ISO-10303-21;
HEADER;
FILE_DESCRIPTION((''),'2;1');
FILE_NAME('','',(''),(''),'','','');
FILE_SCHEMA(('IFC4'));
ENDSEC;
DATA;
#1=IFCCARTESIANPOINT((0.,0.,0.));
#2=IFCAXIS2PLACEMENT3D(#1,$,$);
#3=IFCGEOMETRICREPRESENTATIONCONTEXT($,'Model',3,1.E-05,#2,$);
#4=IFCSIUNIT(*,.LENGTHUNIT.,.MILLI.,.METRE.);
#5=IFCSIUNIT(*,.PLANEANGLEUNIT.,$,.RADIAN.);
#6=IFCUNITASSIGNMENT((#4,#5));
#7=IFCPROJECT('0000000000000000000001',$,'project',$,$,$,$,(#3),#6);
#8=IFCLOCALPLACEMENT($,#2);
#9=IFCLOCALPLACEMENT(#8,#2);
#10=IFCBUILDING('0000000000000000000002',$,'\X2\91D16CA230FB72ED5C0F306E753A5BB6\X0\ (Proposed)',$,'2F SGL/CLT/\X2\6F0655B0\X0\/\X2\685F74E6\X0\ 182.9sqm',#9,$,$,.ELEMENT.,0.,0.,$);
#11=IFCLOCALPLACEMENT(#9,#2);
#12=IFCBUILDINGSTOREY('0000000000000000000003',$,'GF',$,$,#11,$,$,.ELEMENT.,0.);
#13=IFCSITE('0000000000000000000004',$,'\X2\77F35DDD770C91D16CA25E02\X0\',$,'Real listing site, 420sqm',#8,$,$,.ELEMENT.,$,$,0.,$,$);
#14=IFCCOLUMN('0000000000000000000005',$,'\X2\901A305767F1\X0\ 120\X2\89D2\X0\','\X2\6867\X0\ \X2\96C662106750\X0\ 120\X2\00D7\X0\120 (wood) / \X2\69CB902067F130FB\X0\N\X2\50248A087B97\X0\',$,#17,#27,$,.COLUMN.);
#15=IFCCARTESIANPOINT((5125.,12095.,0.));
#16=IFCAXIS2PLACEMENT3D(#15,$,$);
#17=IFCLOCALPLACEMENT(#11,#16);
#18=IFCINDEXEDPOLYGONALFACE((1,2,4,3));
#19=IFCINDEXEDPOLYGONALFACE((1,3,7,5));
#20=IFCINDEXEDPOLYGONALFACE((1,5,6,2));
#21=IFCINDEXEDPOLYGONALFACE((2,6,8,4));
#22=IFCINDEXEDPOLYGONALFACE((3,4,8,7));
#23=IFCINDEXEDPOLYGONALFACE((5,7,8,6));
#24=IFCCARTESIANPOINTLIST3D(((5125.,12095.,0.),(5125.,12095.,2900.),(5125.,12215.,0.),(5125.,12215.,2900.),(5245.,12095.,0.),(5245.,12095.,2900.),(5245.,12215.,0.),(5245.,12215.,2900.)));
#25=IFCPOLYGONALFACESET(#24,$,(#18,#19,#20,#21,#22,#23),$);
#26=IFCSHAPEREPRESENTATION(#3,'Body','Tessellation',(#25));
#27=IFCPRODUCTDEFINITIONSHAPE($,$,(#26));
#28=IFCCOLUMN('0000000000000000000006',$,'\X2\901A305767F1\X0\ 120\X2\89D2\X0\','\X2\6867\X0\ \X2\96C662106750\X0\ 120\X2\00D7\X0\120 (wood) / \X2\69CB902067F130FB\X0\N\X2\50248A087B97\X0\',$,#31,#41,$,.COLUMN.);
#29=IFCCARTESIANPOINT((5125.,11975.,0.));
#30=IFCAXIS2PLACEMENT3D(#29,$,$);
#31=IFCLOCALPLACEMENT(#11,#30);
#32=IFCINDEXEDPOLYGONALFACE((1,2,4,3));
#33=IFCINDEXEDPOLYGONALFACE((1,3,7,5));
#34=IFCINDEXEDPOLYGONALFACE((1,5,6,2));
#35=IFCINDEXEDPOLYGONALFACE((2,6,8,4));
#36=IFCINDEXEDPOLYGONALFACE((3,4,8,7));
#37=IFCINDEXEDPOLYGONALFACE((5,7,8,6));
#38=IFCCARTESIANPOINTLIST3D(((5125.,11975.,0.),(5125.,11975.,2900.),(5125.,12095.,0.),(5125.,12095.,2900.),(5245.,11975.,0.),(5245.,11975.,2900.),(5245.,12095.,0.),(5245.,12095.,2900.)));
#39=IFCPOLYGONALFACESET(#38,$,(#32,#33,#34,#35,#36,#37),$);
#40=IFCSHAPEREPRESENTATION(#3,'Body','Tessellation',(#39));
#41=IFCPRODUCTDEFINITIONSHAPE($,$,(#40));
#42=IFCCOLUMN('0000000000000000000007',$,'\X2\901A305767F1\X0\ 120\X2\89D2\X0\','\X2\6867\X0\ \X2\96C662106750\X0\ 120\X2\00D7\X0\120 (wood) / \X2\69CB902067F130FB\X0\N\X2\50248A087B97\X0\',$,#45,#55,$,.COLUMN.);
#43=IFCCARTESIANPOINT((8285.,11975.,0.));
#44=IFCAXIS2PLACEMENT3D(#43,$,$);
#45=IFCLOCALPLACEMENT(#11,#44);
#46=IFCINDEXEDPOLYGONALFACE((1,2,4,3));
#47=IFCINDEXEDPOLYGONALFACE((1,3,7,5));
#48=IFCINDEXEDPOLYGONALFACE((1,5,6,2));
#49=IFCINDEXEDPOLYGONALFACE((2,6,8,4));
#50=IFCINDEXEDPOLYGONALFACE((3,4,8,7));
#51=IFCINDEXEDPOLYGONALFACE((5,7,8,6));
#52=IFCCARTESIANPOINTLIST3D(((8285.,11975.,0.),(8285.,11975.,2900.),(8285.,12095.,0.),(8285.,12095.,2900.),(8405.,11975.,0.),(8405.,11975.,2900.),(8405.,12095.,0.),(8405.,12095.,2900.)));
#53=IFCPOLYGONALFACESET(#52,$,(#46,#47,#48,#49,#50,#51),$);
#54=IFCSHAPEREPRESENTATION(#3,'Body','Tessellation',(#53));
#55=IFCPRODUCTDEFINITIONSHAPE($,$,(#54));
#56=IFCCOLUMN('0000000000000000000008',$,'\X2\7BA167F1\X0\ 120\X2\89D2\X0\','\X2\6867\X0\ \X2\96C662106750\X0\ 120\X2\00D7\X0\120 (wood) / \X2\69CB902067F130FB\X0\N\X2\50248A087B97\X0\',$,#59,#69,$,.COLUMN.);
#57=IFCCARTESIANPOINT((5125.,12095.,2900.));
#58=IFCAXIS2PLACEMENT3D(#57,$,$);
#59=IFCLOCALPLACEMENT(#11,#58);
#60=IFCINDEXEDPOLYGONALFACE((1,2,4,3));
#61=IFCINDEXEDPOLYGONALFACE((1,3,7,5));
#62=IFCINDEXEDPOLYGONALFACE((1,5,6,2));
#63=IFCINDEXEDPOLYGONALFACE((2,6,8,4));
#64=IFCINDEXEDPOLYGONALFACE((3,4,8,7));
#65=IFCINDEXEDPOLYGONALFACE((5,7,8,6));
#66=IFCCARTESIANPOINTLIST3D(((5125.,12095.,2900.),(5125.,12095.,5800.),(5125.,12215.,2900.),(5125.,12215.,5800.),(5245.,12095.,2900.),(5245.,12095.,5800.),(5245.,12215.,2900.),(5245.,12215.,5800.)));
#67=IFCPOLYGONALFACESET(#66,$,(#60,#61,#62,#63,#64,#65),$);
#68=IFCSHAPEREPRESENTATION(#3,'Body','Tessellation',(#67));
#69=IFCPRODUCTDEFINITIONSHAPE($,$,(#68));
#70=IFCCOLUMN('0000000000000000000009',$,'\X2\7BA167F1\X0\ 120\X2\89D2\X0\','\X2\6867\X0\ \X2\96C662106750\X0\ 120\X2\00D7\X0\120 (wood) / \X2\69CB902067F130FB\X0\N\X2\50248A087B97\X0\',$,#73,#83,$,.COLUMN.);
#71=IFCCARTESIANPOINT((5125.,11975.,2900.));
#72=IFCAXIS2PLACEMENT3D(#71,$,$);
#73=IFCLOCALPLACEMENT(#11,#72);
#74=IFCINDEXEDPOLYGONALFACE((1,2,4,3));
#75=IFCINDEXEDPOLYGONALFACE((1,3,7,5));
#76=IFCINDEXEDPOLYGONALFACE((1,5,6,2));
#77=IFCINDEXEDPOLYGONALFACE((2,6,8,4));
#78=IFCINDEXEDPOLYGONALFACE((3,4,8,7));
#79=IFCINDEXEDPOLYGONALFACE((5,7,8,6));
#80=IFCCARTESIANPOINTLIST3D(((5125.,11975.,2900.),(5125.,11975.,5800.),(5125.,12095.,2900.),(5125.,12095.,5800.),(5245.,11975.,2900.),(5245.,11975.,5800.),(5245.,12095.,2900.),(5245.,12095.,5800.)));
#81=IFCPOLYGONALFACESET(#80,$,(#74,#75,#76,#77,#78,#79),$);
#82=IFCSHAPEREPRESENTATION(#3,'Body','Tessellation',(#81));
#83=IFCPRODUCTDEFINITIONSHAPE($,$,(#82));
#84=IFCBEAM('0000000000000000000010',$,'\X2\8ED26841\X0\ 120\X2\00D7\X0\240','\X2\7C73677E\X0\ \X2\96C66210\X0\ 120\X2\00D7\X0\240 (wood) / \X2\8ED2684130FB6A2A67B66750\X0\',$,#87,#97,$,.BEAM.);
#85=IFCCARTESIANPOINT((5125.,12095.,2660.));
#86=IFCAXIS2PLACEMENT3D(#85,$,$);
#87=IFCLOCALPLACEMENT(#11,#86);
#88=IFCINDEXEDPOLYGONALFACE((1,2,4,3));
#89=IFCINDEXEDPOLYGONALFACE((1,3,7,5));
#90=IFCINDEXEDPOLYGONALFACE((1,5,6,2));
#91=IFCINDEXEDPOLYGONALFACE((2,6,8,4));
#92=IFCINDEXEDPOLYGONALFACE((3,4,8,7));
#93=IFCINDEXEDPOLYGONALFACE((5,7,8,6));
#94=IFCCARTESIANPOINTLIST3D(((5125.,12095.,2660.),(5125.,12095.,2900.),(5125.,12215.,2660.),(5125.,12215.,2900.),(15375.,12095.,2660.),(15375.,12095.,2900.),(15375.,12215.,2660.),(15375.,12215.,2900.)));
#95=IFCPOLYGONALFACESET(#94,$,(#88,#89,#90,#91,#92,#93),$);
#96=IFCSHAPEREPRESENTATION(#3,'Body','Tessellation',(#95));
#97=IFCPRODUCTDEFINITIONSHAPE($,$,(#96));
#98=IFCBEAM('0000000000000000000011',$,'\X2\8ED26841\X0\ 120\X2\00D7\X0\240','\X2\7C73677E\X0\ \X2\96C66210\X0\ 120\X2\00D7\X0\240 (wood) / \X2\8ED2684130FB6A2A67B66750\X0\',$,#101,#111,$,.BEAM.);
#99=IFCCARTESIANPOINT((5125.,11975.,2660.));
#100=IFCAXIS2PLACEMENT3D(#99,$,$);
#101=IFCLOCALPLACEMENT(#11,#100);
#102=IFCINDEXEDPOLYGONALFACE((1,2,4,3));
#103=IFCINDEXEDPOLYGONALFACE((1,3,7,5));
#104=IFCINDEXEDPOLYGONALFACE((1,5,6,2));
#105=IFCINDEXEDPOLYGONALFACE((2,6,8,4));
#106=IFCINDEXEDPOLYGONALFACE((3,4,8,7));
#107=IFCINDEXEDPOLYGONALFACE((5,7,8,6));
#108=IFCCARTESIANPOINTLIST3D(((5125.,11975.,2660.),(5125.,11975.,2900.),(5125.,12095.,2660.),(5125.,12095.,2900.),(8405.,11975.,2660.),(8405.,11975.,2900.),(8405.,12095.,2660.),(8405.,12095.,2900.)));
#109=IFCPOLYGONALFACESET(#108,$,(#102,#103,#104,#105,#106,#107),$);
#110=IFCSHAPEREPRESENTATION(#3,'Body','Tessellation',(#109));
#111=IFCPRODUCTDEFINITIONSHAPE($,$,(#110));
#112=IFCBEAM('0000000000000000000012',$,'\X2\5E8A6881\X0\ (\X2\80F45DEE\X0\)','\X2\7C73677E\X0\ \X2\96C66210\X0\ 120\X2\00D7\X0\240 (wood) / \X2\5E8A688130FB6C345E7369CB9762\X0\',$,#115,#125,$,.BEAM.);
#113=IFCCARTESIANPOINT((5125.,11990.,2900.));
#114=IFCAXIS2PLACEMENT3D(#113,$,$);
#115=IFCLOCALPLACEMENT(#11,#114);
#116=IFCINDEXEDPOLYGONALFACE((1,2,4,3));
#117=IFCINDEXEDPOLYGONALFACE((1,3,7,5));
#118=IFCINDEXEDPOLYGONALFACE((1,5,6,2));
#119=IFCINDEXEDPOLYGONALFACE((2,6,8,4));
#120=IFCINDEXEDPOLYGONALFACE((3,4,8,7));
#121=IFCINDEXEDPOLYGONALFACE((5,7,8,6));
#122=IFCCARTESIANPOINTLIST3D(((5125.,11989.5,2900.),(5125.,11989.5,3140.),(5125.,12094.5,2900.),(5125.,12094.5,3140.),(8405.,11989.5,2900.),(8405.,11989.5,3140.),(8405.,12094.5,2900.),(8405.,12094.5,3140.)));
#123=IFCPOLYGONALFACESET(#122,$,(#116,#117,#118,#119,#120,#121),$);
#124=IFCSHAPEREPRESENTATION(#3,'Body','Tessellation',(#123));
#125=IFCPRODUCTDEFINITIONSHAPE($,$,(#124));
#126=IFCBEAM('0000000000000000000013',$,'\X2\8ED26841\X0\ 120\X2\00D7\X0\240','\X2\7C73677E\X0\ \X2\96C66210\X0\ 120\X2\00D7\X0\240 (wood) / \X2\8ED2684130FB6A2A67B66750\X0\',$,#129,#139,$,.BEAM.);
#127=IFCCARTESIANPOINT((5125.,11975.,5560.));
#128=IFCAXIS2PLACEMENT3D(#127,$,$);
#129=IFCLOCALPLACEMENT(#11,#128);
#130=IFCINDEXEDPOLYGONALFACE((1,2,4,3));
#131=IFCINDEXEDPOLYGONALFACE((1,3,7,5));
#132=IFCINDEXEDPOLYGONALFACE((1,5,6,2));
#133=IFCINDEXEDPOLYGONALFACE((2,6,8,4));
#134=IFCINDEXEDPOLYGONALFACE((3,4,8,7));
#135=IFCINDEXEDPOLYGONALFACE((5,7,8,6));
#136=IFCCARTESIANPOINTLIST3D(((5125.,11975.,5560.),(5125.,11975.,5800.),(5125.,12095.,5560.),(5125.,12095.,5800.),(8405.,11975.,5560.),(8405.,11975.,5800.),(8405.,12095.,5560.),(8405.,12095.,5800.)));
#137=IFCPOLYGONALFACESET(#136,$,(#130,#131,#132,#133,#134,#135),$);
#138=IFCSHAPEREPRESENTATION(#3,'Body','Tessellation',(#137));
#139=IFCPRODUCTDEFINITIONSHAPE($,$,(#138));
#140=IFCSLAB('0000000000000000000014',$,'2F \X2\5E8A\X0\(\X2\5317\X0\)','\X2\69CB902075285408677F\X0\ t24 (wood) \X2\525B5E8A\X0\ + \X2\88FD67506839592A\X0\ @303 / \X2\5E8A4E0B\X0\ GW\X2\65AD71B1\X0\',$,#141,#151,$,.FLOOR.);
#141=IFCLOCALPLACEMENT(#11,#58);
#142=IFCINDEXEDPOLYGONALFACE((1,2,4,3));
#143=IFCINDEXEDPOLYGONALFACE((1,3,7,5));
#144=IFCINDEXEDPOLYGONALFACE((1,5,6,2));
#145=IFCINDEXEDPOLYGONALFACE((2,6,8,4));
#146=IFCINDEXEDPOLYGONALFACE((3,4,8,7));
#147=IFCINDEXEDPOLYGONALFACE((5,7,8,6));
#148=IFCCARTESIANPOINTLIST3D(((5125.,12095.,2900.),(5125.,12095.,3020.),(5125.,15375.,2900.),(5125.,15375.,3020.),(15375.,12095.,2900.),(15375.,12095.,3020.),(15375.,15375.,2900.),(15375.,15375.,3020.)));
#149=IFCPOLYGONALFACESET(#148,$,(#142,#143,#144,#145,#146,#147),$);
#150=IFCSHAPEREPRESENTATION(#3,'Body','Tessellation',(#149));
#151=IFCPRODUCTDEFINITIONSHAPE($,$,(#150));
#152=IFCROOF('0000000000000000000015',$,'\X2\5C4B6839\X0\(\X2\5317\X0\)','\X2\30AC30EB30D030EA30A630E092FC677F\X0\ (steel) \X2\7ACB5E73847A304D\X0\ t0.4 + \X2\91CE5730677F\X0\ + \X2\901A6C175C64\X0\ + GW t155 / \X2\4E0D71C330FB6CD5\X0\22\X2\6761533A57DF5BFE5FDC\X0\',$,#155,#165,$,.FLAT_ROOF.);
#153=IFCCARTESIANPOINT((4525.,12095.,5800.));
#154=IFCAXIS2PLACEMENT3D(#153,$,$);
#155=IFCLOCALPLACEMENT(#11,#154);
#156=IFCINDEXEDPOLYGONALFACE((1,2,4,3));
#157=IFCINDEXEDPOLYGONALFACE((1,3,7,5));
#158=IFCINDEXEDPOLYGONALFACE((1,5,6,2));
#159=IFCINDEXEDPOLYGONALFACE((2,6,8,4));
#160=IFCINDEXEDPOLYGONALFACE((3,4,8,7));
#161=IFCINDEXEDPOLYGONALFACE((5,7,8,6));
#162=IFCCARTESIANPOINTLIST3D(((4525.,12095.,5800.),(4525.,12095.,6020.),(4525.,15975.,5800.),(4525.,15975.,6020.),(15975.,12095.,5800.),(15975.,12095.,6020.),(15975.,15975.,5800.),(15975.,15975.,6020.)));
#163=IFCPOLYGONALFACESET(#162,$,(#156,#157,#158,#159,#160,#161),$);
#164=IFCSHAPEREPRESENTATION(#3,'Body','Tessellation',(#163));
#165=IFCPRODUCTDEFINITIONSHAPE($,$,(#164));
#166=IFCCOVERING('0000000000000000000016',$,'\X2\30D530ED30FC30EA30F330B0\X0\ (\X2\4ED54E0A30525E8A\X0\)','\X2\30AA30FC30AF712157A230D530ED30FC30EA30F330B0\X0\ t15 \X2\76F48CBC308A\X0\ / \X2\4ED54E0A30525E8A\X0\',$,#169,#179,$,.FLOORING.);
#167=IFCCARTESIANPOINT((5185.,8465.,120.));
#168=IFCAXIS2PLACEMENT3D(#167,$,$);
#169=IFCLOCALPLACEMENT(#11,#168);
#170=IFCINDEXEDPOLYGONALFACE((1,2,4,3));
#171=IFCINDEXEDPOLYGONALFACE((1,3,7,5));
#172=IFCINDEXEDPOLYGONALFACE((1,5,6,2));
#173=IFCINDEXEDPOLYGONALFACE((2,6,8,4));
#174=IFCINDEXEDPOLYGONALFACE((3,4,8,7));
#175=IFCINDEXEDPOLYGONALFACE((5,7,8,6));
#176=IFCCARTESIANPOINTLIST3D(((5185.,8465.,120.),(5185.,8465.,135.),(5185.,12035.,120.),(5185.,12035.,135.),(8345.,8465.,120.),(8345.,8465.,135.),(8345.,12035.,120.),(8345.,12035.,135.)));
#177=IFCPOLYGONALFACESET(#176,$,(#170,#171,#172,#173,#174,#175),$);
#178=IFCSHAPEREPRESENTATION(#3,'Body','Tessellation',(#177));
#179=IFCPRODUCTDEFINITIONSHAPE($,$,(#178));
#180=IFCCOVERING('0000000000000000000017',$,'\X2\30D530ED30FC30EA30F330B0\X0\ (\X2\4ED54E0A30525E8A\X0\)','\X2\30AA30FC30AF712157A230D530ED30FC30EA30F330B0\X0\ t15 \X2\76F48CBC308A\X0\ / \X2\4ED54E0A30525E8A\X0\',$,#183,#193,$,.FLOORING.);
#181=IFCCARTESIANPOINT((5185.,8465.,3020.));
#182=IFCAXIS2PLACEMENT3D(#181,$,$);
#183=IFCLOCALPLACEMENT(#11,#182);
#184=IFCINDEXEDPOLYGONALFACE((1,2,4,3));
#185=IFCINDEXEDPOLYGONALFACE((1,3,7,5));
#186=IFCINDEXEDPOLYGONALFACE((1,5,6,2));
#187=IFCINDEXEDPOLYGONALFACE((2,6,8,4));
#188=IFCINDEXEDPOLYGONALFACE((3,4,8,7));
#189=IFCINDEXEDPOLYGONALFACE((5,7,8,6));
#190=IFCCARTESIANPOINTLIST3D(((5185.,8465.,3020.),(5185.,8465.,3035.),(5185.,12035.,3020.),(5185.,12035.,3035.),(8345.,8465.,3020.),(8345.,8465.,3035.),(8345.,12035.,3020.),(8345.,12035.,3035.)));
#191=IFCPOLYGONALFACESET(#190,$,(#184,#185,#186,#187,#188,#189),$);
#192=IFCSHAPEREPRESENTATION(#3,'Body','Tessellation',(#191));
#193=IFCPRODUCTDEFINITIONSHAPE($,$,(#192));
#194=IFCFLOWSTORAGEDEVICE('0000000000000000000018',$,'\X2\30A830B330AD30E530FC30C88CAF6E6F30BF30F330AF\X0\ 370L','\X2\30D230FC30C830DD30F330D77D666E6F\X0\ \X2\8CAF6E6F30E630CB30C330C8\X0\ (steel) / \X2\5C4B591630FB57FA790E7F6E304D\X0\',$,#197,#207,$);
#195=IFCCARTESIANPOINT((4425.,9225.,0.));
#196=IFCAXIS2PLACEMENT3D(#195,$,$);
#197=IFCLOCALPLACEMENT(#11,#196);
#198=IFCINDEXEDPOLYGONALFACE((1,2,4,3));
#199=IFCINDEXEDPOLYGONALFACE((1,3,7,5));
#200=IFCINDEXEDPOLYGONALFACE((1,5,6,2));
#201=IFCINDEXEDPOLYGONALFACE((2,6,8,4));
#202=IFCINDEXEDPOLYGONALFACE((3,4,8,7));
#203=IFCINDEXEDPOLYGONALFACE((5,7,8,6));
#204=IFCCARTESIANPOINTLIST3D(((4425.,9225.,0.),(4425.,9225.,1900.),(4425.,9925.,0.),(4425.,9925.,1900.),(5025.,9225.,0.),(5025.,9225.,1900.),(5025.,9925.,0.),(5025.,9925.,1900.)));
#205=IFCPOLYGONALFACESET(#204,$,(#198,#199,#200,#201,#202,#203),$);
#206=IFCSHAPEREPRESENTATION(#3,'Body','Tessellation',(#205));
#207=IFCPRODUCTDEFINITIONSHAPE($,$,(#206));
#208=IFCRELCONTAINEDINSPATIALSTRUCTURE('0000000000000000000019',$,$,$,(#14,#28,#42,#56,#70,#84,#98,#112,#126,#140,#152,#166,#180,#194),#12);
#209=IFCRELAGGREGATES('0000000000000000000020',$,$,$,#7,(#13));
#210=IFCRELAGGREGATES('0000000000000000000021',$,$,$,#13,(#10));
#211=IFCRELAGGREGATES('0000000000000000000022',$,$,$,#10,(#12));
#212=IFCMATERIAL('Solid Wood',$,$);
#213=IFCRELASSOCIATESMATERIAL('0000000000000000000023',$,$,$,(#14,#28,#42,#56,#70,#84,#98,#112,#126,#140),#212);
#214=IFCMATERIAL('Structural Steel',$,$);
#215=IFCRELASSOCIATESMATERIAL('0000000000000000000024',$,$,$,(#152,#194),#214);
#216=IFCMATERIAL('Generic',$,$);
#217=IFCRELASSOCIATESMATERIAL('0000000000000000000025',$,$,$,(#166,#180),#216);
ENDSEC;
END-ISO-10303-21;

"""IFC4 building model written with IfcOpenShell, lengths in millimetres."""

from ifc_helpers import new_model, si_unit, frame, frame_2d, origin, place, context, project, spatial, rectangle, extrude, material, element, save


model = new_model("IFC4")

# Units and contexts
model_context = context("Model", 3, precision=1e-05, world=origin())
ifc_project = project(units=[si_unit("LENGTHUNIT", "METRE", prefix="MILLI"), si_unit("PLANEANGLEUNIT", "RADIAN")], contexts=[model_context])

# Site, building, storey
site_placement = place(None, origin())
site = spatial("IfcSite", under=ifc_project, at=site_placement, Name="石川県金沢市", ObjectType="Real listing site, 420sqm", CompositionType="ELEMENT", RefElevation=0.0)
building_placement = place(site_placement, origin())
building = spatial("IfcBuilding", under=site, at=building_placement, Name="金沢・狭小の町家 (Proposed)", ObjectType="2F SGL/CLT/漆喰/桟瓦 182.9sqm", CompositionType="ELEMENT", ElevationOfRefHeight=0.0, ElevationOfTerrain=0.0)
storey_placement = place(building_placement, origin())
storey = spatial("IfcBuildingStorey", under=building, at=storey_placement, Name="GF", CompositionType="ELEMENT", Elevation=0.0)

# Columns
ifc_material_1 = material(Name="Solid Wood")
column_1_placement = place(storey_placement, frame((5125.0, 12095.0, 0.0)))
element("IfcColumn", 1, at=column_1_placement, inside=storey, material=ifc_material_1, Name="通し柱 120角", Description="桧 集成材 120×120 (wood) / 構造柱・N値計算", PredefinedType="COLUMN", context=model_context, shape_type="SweptSolid", body=[
    extrude(rectangle(XDim=120.0, YDim=120.0, at=frame_2d((60.0, 60.0))), frame((5125.0, 12095.0, 0.0)), (0.0, 0.0, 1.0), 2900.0),
])
column_2_placement = place(storey_placement, frame((5125.0, 11975.0, 0.0)))
element("IfcColumn", 2, at=column_2_placement, inside=storey, material=ifc_material_1, Name="通し柱 120角", Description="桧 集成材 120×120 (wood) / 構造柱・N値計算", PredefinedType="COLUMN", context=model_context, shape_type="SweptSolid", body=[
    extrude(rectangle(XDim=120.0, YDim=120.0, at=frame_2d((60.0, 60.0))), frame((5125.0, 11975.0, 0.0)), (0.0, 0.0, 1.0), 2900.0),
])
column_3_placement = place(storey_placement, frame((8285.0, 11975.0, 0.0)))
element("IfcColumn", 3, at=column_3_placement, inside=storey, material=ifc_material_1, Name="通し柱 120角", Description="桧 集成材 120×120 (wood) / 構造柱・N値計算", PredefinedType="COLUMN", context=model_context, shape_type="SweptSolid", body=[
    extrude(rectangle(XDim=120.0, YDim=120.0, at=frame_2d((60.0, 60.0))), frame((8285.0, 11975.0, 0.0)), (0.0, 0.0, 1.0), 2900.0),
])
column_4_placement = place(storey_placement, frame((5125.0, 12095.0, 2900.0)))
element("IfcColumn", 4, at=column_4_placement, inside=storey, material=ifc_material_1, Name="管柱 120角", Description="桧 集成材 120×120 (wood) / 構造柱・N値計算", PredefinedType="COLUMN", context=model_context, shape_type="SweptSolid", body=[
    extrude(rectangle(XDim=120.0, YDim=120.0, at=frame_2d((60.0, 60.0))), frame((5125.0, 12095.0, 2900.0)), (0.0, 0.0, 1.0), 2900.0),
])
column_5_placement = place(storey_placement, frame((5125.0, 11975.0, 2900.0)))
element("IfcColumn", 5, at=column_5_placement, inside=storey, material=ifc_material_1, Name="管柱 120角", Description="桧 集成材 120×120 (wood) / 構造柱・N値計算", PredefinedType="COLUMN", context=model_context, shape_type="SweptSolid", body=[
    extrude(rectangle(XDim=120.0, YDim=120.0, at=frame_2d((60.0, 60.0))), frame((5125.0, 11975.0, 2900.0)), (0.0, 0.0, 1.0), 2900.0),
])

# Beams
beam_1_placement = place(storey_placement, frame((5125.0, 12095.0, 2660.0)))
element("IfcBeam", 6, at=beam_1_placement, inside=storey, material=ifc_material_1, Name="軒桁 120×240", Description="米松 集成 120×240 (wood) / 軒桁・横架材", PredefinedType="BEAM", context=model_context, shape_type="SweptSolid", body=[
    extrude(rectangle(XDim=10250.0, YDim=120.0, at=frame_2d((5125.0, 60.0))), frame((5125.0, 12095.0, 2660.0)), (0.0, 0.0, 1.0), 240.0),
])
beam_2_placement = place(storey_placement, frame((5125.0, 11975.0, 2660.0)))
element("IfcBeam", 7, at=beam_2_placement, inside=storey, material=ifc_material_1, Name="軒桁 120×240", Description="米松 集成 120×240 (wood) / 軒桁・横架材", PredefinedType="BEAM", context=model_context, shape_type="SweptSolid", body=[
    extrude(rectangle(XDim=3280.0, YDim=120.0, at=frame_2d((1640.0, 60.0))), frame((5125.0, 11975.0, 2660.0)), (0.0, 0.0, 1.0), 240.0),
])
beam_3_placement = place(storey_placement, frame((5125.0, 11990.0, 2900.0)))
element("IfcBeam", 8, at=beam_3_placement, inside=storey, material=ifc_material_1, Name="床梁 (胴差)", Description="米松 集成 120×240 (wood) / 床梁・水平構面", PredefinedType="BEAM", context=model_context, shape_type="SweptSolid", body=[
    extrude(rectangle(XDim=3280.0, YDim=105.0, at=frame_2d((1640.0, 52.0))), frame((5125.0, 11990.0, 2900.0)), (0.0, 0.0, 1.0), 240.0),
])
beam_4_placement = place(storey_placement, frame((5125.0, 11975.0, 5560.0)))
element("IfcBeam", 9, at=beam_4_placement, inside=storey, material=ifc_material_1, Name="軒桁 120×240", Description="米松 集成 120×240 (wood) / 軒桁・横架材", PredefinedType="BEAM", context=model_context, shape_type="SweptSolid", body=[
    extrude(rectangle(XDim=3280.0, YDim=120.0, at=frame_2d((1640.0, 60.0))), frame((5125.0, 11975.0, 5560.0)), (0.0, 0.0, 1.0), 240.0),
])

# Slab
slab_1_placement = place(storey_placement, frame((5125.0, 12095.0, 2900.0)))
element("IfcSlab", 10, at=slab_1_placement, inside=storey, material=ifc_material_1, Name="2F 床(北)", Description="構造用合板 t24 (wood) 剛床 + 製材根太 @303 / 床下 GW断熱", PredefinedType="FLOOR", context=model_context, shape_type="SweptSolid", body=[
    extrude(rectangle(XDim=10250.0, YDim=3280.0, at=frame_2d((5125.0, 1640.0))), frame((5125.0, 12095.0, 2900.0)), (0.0, 0.0, 1.0), 120.0),
])

# Roof
ifc_material_2 = material(Name="Structural Steel")
for number, where, name in (
    (11, (4525.0, 12095.0, 5800.0), "屋根(北)"),
):
    element("IfcRoof", number, at=place(storey_placement, frame(where)), inside=storey, material=ifc_material_2, Name=name, Description="ガルバリウム鋼板 (steel) 立平葺き t0.4 + 野地板 + 通気層 + GW t155 / 不燃・法22条区域対応", PredefinedType="FLAT_ROOF", context=model_context, shape_type="SweptSolid", body=[
        extrude(rectangle(XDim=11450.0, YDim=3880.0, at=frame_2d((5725.0, 1940.0))), frame((4525.0, 12095.0, 5800.0)), (0.0, 0.0, 1.0), 220.0),
    ])

# Coverings
ifc_material_3 = material(Name="Generic")
covering_1_placement = place(storey_placement, frame((5185.0, 8465.0, 120.0)))
element("IfcCovering", 12, at=covering_1_placement, inside=storey, material=ifc_material_3, Name="フローリング (仕上げ床)", Description="オーク無垢フローリング t15 直貼り / 仕上げ床", PredefinedType="FLOORING", context=model_context, shape_type="SweptSolid", body=[
    extrude(rectangle(XDim=3160.0, YDim=3570.0, at=frame_2d((1580.0, 1785.0))), frame((5185.0, 8465.0, 120.0)), (0.0, 0.0, 1.0), 15.0),
])
covering_2_placement = place(storey_placement, frame((5185.0, 8465.0, 3020.0)))
element("IfcCovering", 13, at=covering_2_placement, inside=storey, material=ifc_material_3, Name="フローリング (仕上げ床)", Description="オーク無垢フローリング t15 直貼り / 仕上げ床", PredefinedType="FLOORING", context=model_context, shape_type="SweptSolid", body=[
    extrude(rectangle(XDim=3160.0, YDim=3570.0, at=frame_2d((1580.0, 1785.0))), frame((5185.0, 8465.0, 3020.0)), (0.0, 0.0, 1.0), 15.0),
])

# Flow storage device
flow_storage_device_placement = place(storey_placement, frame((4425.0, 9225.0, 0.0)))
element("IfcFlowStorageDevice", 14, at=flow_storage_device_placement, inside=storey, material=ifc_material_2, Name="エコキュート貯湯タンク 370L", Description="ヒートポンプ給湯 貯湯ユニット (steel) / 屋外・基礎置き", context=model_context, shape_type="SweptSolid", body=[
    extrude(rectangle(XDim=600.0, YDim=700.0, at=frame_2d((300.0, 350.0))), frame((4425.0, 9225.0, 0.0)), (0.0, 0.0, 1.0), 1900.0),
])

save(model, "model.ifc")
